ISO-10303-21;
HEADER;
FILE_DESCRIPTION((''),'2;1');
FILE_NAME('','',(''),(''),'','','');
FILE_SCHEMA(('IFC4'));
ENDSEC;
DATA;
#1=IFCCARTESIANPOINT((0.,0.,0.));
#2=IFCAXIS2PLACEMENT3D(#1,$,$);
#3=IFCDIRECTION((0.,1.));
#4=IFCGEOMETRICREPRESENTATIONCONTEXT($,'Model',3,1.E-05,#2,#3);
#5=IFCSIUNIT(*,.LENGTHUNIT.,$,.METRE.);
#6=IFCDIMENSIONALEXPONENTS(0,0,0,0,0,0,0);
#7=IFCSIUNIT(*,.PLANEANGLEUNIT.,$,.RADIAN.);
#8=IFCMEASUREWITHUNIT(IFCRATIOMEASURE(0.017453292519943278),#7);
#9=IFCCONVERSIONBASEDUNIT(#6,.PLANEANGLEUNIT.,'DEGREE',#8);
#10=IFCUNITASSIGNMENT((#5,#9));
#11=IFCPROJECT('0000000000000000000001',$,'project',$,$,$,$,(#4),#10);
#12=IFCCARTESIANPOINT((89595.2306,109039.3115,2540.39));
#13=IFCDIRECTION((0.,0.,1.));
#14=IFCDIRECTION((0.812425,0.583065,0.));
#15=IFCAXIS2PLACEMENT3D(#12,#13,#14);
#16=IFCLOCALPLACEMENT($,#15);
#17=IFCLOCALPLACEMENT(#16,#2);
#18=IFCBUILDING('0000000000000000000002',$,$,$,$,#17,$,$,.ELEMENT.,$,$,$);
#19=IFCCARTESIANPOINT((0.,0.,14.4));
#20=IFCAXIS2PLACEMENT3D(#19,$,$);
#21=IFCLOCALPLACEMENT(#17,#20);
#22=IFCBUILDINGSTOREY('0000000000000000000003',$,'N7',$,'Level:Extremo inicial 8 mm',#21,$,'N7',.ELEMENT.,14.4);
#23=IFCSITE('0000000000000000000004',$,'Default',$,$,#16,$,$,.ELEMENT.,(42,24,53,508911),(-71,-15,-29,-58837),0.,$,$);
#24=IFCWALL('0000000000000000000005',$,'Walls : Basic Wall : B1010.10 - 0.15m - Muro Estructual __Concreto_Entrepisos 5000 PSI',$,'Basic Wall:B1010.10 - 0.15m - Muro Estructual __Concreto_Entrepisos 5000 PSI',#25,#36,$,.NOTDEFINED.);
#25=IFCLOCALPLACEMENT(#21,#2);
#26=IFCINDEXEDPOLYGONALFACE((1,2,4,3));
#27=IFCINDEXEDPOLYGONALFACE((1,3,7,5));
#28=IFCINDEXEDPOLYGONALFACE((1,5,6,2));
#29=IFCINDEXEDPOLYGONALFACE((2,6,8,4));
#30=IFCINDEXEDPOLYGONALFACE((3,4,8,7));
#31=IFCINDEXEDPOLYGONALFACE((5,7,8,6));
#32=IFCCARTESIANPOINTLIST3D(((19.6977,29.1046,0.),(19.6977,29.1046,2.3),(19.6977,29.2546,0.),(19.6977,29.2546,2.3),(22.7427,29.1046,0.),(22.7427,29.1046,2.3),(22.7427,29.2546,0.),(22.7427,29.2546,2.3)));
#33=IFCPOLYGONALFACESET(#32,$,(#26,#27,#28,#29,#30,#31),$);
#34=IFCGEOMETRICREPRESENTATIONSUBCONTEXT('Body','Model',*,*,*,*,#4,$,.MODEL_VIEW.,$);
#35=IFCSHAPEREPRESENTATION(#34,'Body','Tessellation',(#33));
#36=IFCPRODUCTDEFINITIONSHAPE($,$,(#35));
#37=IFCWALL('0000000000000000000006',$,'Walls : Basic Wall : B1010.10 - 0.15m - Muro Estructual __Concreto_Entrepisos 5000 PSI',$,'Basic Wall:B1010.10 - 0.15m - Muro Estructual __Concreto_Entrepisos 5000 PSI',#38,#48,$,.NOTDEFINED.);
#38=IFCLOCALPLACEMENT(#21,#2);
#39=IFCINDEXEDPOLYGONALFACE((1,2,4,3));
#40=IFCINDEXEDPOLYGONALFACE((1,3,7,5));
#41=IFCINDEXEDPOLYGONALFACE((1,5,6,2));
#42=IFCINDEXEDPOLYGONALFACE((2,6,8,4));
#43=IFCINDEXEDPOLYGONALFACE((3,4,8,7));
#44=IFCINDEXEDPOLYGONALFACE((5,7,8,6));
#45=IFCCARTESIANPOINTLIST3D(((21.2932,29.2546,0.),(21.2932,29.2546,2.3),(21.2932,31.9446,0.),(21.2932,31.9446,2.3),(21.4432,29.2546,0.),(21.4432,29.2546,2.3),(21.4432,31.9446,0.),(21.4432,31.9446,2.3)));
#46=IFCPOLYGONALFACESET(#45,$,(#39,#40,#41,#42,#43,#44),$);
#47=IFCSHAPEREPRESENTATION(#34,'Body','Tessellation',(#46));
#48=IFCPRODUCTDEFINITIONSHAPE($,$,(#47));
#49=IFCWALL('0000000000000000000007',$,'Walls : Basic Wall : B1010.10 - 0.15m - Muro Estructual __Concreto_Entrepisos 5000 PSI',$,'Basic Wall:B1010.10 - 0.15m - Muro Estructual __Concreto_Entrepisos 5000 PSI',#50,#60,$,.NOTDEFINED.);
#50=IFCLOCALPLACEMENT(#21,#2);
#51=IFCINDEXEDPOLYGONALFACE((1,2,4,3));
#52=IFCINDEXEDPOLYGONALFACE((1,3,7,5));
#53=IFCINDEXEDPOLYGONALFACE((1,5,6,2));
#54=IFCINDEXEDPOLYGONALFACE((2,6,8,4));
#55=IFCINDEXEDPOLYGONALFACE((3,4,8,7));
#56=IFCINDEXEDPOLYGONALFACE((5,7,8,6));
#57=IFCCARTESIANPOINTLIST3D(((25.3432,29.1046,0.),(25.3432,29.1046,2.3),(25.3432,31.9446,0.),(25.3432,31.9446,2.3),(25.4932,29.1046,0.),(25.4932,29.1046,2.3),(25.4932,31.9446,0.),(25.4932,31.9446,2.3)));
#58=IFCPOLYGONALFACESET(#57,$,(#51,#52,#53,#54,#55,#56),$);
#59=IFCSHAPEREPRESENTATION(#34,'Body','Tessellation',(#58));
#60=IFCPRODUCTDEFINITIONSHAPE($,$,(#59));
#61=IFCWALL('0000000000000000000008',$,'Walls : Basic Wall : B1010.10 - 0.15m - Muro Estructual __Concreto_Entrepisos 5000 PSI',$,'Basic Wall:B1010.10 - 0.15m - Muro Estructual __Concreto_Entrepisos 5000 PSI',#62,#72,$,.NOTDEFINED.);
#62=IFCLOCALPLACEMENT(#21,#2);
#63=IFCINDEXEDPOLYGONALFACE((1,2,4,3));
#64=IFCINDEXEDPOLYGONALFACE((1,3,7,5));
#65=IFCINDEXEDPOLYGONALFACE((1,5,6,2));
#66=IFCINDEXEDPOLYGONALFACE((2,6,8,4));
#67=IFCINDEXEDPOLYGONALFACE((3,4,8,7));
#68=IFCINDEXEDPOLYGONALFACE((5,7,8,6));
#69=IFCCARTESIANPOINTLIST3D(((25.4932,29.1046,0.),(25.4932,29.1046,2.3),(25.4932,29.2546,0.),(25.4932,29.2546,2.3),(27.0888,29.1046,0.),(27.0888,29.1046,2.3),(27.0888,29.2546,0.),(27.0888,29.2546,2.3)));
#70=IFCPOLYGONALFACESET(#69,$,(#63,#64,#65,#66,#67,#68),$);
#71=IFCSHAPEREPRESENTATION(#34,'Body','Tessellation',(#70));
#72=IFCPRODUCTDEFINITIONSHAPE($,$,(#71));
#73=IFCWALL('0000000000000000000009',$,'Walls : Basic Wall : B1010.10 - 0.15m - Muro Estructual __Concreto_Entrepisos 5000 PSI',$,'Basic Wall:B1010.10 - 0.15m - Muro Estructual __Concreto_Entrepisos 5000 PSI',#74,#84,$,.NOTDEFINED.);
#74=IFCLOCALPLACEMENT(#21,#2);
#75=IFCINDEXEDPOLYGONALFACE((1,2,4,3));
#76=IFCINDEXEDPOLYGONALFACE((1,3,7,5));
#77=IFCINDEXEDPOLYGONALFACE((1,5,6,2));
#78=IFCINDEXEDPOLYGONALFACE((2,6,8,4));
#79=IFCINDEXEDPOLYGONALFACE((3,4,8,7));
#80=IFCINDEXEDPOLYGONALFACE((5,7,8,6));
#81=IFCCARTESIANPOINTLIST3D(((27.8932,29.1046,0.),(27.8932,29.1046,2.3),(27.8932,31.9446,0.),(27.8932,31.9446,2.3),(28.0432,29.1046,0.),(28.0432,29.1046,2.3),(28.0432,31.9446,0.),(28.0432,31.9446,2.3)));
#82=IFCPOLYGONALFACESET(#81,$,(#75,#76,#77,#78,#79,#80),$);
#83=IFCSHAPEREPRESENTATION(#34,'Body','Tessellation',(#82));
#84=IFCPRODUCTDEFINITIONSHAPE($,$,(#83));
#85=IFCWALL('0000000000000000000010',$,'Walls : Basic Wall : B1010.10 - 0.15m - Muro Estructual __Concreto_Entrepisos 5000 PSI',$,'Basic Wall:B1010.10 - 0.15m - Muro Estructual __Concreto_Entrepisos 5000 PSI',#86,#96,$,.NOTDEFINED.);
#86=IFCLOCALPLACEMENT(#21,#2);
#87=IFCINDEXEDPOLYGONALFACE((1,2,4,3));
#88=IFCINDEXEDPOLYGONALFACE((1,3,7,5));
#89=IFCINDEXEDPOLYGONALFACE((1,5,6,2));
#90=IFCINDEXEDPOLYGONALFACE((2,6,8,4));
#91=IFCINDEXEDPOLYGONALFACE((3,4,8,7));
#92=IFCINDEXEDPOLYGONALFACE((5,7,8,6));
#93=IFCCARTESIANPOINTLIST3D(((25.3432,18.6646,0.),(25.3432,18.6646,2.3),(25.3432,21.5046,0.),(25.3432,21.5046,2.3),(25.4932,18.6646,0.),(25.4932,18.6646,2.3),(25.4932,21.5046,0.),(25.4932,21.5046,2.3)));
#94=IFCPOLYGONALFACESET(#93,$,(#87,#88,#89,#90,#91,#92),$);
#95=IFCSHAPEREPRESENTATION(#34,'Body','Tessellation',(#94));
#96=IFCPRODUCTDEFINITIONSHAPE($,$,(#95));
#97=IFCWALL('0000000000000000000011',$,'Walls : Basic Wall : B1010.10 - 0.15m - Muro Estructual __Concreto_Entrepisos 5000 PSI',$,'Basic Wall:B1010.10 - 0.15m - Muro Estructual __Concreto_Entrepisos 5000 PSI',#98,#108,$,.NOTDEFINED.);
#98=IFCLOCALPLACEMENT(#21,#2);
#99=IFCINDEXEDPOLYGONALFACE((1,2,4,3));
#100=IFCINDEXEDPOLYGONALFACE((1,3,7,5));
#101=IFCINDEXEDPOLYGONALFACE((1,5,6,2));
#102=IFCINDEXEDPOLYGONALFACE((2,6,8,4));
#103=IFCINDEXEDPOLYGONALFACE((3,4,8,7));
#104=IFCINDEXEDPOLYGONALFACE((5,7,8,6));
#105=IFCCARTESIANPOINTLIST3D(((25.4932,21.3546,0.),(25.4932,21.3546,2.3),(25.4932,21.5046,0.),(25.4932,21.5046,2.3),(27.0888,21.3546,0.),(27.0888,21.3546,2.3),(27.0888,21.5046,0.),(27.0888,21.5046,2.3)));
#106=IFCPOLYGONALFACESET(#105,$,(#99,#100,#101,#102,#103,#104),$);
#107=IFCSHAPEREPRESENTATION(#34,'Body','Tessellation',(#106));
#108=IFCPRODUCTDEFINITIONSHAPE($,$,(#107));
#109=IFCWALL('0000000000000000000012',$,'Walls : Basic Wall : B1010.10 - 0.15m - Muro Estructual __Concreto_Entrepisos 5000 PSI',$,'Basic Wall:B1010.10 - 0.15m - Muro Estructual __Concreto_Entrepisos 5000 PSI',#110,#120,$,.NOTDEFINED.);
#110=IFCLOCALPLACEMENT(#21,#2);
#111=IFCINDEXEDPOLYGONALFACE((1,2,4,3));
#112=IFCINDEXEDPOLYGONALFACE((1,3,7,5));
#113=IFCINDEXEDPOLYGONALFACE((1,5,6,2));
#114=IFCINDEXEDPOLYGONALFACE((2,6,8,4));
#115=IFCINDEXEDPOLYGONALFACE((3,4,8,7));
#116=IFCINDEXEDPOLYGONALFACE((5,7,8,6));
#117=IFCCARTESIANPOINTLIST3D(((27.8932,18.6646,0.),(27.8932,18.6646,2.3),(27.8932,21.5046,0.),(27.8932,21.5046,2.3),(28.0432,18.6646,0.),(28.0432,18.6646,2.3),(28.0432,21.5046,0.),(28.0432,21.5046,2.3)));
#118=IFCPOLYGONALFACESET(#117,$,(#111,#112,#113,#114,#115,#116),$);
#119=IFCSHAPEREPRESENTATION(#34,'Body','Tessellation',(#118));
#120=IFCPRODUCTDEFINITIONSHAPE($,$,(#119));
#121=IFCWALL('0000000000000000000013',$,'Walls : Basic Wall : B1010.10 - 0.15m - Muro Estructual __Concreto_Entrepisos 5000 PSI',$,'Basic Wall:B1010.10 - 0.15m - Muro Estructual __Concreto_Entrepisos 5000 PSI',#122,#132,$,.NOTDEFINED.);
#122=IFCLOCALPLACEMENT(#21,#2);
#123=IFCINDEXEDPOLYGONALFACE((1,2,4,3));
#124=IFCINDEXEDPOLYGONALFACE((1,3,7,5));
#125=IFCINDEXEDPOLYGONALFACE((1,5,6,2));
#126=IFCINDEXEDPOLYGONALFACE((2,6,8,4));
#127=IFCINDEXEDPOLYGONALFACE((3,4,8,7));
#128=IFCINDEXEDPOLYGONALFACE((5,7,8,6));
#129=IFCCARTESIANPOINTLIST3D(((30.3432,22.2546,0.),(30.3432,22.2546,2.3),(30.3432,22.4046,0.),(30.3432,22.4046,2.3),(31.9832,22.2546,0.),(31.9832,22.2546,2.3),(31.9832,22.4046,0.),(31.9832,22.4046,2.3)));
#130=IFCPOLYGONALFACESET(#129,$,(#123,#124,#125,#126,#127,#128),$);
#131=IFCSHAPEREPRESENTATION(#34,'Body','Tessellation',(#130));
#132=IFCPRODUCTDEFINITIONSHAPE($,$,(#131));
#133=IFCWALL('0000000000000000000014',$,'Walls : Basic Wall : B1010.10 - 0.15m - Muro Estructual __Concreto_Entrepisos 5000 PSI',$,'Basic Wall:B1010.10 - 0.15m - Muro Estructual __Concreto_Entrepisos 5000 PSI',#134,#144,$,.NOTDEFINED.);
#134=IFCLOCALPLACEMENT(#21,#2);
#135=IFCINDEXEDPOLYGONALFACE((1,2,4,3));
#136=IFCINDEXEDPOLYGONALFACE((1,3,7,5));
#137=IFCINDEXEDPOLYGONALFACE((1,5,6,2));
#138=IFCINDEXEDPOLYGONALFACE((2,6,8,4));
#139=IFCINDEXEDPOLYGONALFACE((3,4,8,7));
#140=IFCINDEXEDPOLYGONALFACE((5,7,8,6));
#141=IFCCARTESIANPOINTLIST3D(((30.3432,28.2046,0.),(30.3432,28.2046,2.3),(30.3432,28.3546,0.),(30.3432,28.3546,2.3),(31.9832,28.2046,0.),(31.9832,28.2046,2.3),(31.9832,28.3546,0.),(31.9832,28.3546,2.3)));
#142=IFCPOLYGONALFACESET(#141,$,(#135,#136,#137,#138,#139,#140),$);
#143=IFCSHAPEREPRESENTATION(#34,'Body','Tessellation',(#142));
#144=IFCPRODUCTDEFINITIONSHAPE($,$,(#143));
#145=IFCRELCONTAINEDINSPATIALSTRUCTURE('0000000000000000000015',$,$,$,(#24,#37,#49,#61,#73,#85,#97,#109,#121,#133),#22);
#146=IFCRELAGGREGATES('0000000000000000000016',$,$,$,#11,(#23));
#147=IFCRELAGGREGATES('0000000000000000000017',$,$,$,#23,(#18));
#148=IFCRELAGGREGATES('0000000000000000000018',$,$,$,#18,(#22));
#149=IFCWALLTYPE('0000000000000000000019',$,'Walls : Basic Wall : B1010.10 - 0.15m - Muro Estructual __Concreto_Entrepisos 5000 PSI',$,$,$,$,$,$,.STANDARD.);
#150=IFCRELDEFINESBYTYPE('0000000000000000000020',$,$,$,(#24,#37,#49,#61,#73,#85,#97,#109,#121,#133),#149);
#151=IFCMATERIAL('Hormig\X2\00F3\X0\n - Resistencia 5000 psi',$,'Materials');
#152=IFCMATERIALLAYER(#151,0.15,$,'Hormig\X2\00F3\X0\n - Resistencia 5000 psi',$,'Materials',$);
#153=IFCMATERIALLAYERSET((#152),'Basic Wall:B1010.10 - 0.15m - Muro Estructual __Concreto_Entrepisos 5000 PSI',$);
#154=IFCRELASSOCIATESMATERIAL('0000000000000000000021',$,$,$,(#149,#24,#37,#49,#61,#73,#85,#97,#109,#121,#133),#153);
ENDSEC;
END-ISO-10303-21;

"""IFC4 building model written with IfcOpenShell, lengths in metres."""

from ifc_helpers import new_model, entity, si_unit, converted_unit, direction, frame, frame_2d, origin, place, context, subcontext, project, spatial, rectangle, extrude, material, layer, layer_set, layer_usage, type_object, element, save


model = new_model("IFC4")

# Units and contexts
model_context = context("Model", 3, precision=1e-05, world=origin(), true_north=direction((0.0, 1.0)))
body_context = subcontext(model_context, "Body", "Model", "MODEL_VIEW")
ifc_project = project(units=[si_unit("LENGTHUNIT", "METRE"), converted_unit("PLANEANGLEUNIT", "DEGREE", entity("IfcRatioMeasure", 0.017453292519943278), si_unit("PLANEANGLEUNIT", "RADIAN"), dimensions=[0, 0, 0, 0, 0, 0, 0])], contexts=[model_context])

# Site, building, storey
site_placement = place(None, frame((89595.2306, 109039.3115, 2540.39), z_axis=(0.0, 0.0, 1.0), x_axis=(0.812425, 0.583065, 0.0)))
site = spatial("IfcSite", under=ifc_project, at=site_placement, Name="Default", CompositionType="ELEMENT", RefLatitude=(42, 24, 53, 508911), RefLongitude=(-71, -15, -29, -58837), RefElevation=0.0)
building_placement = place(site_placement, origin())
building = spatial("IfcBuilding", under=site, at=building_placement, CompositionType="ELEMENT")
storey_placement = place(building_placement, frame((0.0, 0.0, 14.4)))
storey = spatial("IfcBuildingStorey", under=building, at=storey_placement, Name="N7", ObjectType="Level:Extremo inicial 8 mm", LongName="N7", CompositionType="ELEMENT", Elevation=14.4)

# Walls
ifc_material_1 = material(Name="Hormigón - Resistencia 5000 psi", Category="Materials")
ifc_layer_1 = layer(ifc_material_1, 0.15, Name="Hormigón - Resistencia 5000 psi", Category="Materials")
ifc_layer_set_1 = layer_set([ifc_layer_1], Name="Basic Wall:B1010.10 - 0.15m - Muro Estructual __Concreto_Entrepisos 5000 PSI")
wall_type_1 = type_object("IfcWallType", Name="Walls : Basic Wall : B1010.10 - 0.15m - Muro Estructual __Concreto_Entrepisos 5000 PSI", PredefinedType="STANDARD", material=ifc_layer_set_1)
ifc_layer_usage_1 = layer_usage(ifc_layer_set_1, "AXIS2", "NEGATIVE", 0.075)
wall_1_placement = place(storey_placement, frame((19.6977, 29.1796, 0.0)))
element("IfcWall", 1, at=wall_1_placement, inside=storey, type_object=wall_type_1, material=ifc_layer_usage_1, Name="Walls : Basic Wall : B1010.10 - 0.15m - Muro Estructual __Concreto_Entrepisos 5000 PSI", ObjectType="Basic Wall:B1010.10 - 0.15m - Muro Estructual __Concreto_Entrepisos 5000 PSI", PredefinedType="NOTDEFINED", context=body_context, shape_type="SweptSolid", body=[
    extrude(rectangle(XDim=3.045, YDim=0.15, at=frame_2d((1.5225, 0.0), x_axis=(-1.0, 0.0))), origin(), (0.0, 0.0, 1.0), 2.3),
])
ifc_layer_usage_2 = layer_usage(ifc_layer_set_1, "AXIS2", "NEGATIVE", 0.075)
wall_2_placement = place(storey_placement, frame((21.3682, 31.9446, 0.0), z_axis=(0.0, 0.0, 1.0), x_axis=(0.0, -1.0, 0.0)))
element("IfcWall", 2, at=wall_2_placement, inside=storey, type_object=wall_type_1, material=ifc_layer_usage_2, Name="Walls : Basic Wall : B1010.10 - 0.15m - Muro Estructual __Concreto_Entrepisos 5000 PSI", ObjectType="Basic Wall:B1010.10 - 0.15m - Muro Estructual __Concreto_Entrepisos 5000 PSI", PredefinedType="NOTDEFINED", context=body_context, shape_type="SweptSolid", body=[
    extrude(rectangle(XDim=2.69, YDim=0.15, at=frame_2d((1.345, 0.0), x_axis=(-1.0, 0.0))), origin(), (0.0, 0.0, 1.0), 2.3),
])
ifc_layer_usage_3 = layer_usage(ifc_layer_set_1, "AXIS2", "NEGATIVE", 0.075)
wall_3_placement = place(storey_placement, frame((25.4182, 31.9446, 0.0), z_axis=(0.0, 0.0, 1.0), x_axis=(0.0, -1.0, 0.0)))
element("IfcWall", 3, at=wall_3_placement, inside=storey, type_object=wall_type_1, material=ifc_layer_usage_3, Name="Walls : Basic Wall : B1010.10 - 0.15m - Muro Estructual __Concreto_Entrepisos 5000 PSI", ObjectType="Basic Wall:B1010.10 - 0.15m - Muro Estructual __Concreto_Entrepisos 5000 PSI", PredefinedType="NOTDEFINED", context=body_context, shape_type="SweptSolid", body=[
    extrude(rectangle(XDim=2.84, YDim=0.15, at=frame_2d((1.42, 0.0), x_axis=(-1.0, 0.0))), origin(), (0.0, 0.0, 1.0), 2.3),
])
ifc_layer_usage_4 = layer_usage(ifc_layer_set_1, "AXIS2", "NEGATIVE", 0.075)
wall_4_placement = place(storey_placement, frame((27.0888, 29.1796, 0.0), z_axis=(0.0, 0.0, 1.0), x_axis=(-1.0, 0.0, 0.0)))
element("IfcWall", 4, at=wall_4_placement, inside=storey, type_object=wall_type_1, material=ifc_layer_usage_4, Name="Walls : Basic Wall : B1010.10 - 0.15m - Muro Estructual __Concreto_Entrepisos 5000 PSI", ObjectType="Basic Wall:B1010.10 - 0.15m - Muro Estructual __Concreto_Entrepisos 5000 PSI", PredefinedType="NOTDEFINED", context=body_context, shape_type="SweptSolid", body=[
    extrude(rectangle(XDim=1.5955, YDim=0.15, at=frame_2d((0.7978, 0.0), x_axis=(-1.0, 0.0))), origin(), (0.0, 0.0, 1.0), 2.3),
])
ifc_layer_usage_5 = layer_usage(ifc_layer_set_1, "AXIS2", "NEGATIVE", 0.075)
wall_5_placement = place(storey_placement, frame((27.9682, 31.9446, 0.0), z_axis=(0.0, 0.0, 1.0), x_axis=(0.0, -1.0, 0.0)))
element("IfcWall", 5, at=wall_5_placement, inside=storey, type_object=wall_type_1, material=ifc_layer_usage_5, Name="Walls : Basic Wall : B1010.10 - 0.15m - Muro Estructual __Concreto_Entrepisos 5000 PSI", ObjectType="Basic Wall:B1010.10 - 0.15m - Muro Estructual __Concreto_Entrepisos 5000 PSI", PredefinedType="NOTDEFINED", context=body_context, shape_type="SweptSolid", body=[
    extrude(rectangle(XDim=2.84, YDim=0.15, at=frame_2d((1.42, 0.0), x_axis=(-1.0, 0.0))), origin(), (0.0, 0.0, 1.0), 2.3),
])
ifc_layer_usage_6 = layer_usage(ifc_layer_set_1, "AXIS2", "NEGATIVE", 0.075)
wall_6_placement = place(storey_placement, frame((25.4182, 18.6646, 0.0), z_axis=(0.0, 0.0, 1.0), x_axis=(0.0, 1.0, 0.0)))
element("IfcWall", 6, at=wall_6_placement, inside=storey, type_object=wall_type_1, material=ifc_layer_usage_6, Name="Walls : Basic Wall : B1010.10 - 0.15m - Muro Estructual __Concreto_Entrepisos 5000 PSI", ObjectType="Basic Wall:B1010.10 - 0.15m - Muro Estructual __Concreto_Entrepisos 5000 PSI", PredefinedType="NOTDEFINED", context=body_context, shape_type="SweptSolid", body=[
    extrude(rectangle(XDim=2.84, YDim=0.15, at=frame_2d((1.42, 0.0), x_axis=(-1.0, 0.0))), origin(), (0.0, 0.0, 1.0), 2.3),
])
ifc_layer_usage_7 = layer_usage(ifc_layer_set_1, "AXIS2", "NEGATIVE", 0.075)
wall_7_placement = place(storey_placement, frame((27.0888, 21.4296, 0.0), z_axis=(0.0, 0.0, 1.0), x_axis=(-1.0, 0.0, 0.0)))
element("IfcWall", 7, at=wall_7_placement, inside=storey, type_object=wall_type_1, material=ifc_layer_usage_7, Name="Walls : Basic Wall : B1010.10 - 0.15m - Muro Estructual __Concreto_Entrepisos 5000 PSI", ObjectType="Basic Wall:B1010.10 - 0.15m - Muro Estructual __Concreto_Entrepisos 5000 PSI", PredefinedType="NOTDEFINED", context=body_context, shape_type="SweptSolid", body=[
    extrude(rectangle(XDim=1.5955, YDim=0.15, at=frame_2d((0.7978, 0.0), x_axis=(-1.0, 0.0))), origin(), (0.0, 0.0, 1.0), 2.3),
])
ifc_layer_usage_8 = layer_usage(ifc_layer_set_1, "AXIS2", "NEGATIVE", 0.075)
wall_8_placement = place(storey_placement, frame((27.9682, 18.6646, 0.0), z_axis=(0.0, 0.0, 1.0), x_axis=(0.0, 1.0, 0.0)))
element("IfcWall", 8, at=wall_8_placement, inside=storey, type_object=wall_type_1, material=ifc_layer_usage_8, Name="Walls : Basic Wall : B1010.10 - 0.15m - Muro Estructual __Concreto_Entrepisos 5000 PSI", ObjectType="Basic Wall:B1010.10 - 0.15m - Muro Estructual __Concreto_Entrepisos 5000 PSI", PredefinedType="NOTDEFINED", context=body_context, shape_type="SweptSolid", body=[
    extrude(rectangle(XDim=2.84, YDim=0.15, at=frame_2d((1.42, 0.0), x_axis=(-1.0, 0.0))), origin(), (0.0, 0.0, 1.0), 2.3),
])
ifc_layer_usage_9 = layer_usage(ifc_layer_set_1, "AXIS2", "NEGATIVE", 0.075)
wall_9_placement = place(storey_placement, frame((31.9832, 22.3296, 0.0), z_axis=(0.0, 0.0, 1.0), x_axis=(-1.0, 0.0, 0.0)))
element("IfcWall", 9, at=wall_9_placement, inside=storey, type_object=wall_type_1, material=ifc_layer_usage_9, Name="Walls : Basic Wall : B1010.10 - 0.15m - Muro Estructual __Concreto_Entrepisos 5000 PSI", ObjectType="Basic Wall:B1010.10 - 0.15m - Muro Estructual __Concreto_Entrepisos 5000 PSI", PredefinedType="NOTDEFINED", context=body_context, shape_type="SweptSolid", body=[
    extrude(rectangle(XDim=1.64, YDim=0.15, at=frame_2d((0.82, 0.0), x_axis=(-1.0, 0.0))), origin(), (0.0, 0.0, 1.0), 2.3),
])
ifc_layer_usage_10 = layer_usage(ifc_layer_set_1, "AXIS2", "POSITIVE", -0.075)
wall_10_placement = place(storey_placement, frame((31.9832, 28.2796, 0.0), z_axis=(0.0, 0.0, 1.0), x_axis=(-1.0, 0.0, 0.0)))
element("IfcWall", 10, at=wall_10_placement, inside=storey, type_object=wall_type_1, material=ifc_layer_usage_10, Name="Walls : Basic Wall : B1010.10 - 0.15m - Muro Estructual __Concreto_Entrepisos 5000 PSI", ObjectType="Basic Wall:B1010.10 - 0.15m - Muro Estructual __Concreto_Entrepisos 5000 PSI", PredefinedType="NOTDEFINED", context=body_context, shape_type="SweptSolid", body=[
    extrude(rectangle(XDim=1.64, YDim=0.15, at=frame_2d((0.82, 0.0), x_axis=(-1.0, 0.0))), origin(), (0.0, 0.0, 1.0), 2.3),
])

save(model, "model.ifc")
